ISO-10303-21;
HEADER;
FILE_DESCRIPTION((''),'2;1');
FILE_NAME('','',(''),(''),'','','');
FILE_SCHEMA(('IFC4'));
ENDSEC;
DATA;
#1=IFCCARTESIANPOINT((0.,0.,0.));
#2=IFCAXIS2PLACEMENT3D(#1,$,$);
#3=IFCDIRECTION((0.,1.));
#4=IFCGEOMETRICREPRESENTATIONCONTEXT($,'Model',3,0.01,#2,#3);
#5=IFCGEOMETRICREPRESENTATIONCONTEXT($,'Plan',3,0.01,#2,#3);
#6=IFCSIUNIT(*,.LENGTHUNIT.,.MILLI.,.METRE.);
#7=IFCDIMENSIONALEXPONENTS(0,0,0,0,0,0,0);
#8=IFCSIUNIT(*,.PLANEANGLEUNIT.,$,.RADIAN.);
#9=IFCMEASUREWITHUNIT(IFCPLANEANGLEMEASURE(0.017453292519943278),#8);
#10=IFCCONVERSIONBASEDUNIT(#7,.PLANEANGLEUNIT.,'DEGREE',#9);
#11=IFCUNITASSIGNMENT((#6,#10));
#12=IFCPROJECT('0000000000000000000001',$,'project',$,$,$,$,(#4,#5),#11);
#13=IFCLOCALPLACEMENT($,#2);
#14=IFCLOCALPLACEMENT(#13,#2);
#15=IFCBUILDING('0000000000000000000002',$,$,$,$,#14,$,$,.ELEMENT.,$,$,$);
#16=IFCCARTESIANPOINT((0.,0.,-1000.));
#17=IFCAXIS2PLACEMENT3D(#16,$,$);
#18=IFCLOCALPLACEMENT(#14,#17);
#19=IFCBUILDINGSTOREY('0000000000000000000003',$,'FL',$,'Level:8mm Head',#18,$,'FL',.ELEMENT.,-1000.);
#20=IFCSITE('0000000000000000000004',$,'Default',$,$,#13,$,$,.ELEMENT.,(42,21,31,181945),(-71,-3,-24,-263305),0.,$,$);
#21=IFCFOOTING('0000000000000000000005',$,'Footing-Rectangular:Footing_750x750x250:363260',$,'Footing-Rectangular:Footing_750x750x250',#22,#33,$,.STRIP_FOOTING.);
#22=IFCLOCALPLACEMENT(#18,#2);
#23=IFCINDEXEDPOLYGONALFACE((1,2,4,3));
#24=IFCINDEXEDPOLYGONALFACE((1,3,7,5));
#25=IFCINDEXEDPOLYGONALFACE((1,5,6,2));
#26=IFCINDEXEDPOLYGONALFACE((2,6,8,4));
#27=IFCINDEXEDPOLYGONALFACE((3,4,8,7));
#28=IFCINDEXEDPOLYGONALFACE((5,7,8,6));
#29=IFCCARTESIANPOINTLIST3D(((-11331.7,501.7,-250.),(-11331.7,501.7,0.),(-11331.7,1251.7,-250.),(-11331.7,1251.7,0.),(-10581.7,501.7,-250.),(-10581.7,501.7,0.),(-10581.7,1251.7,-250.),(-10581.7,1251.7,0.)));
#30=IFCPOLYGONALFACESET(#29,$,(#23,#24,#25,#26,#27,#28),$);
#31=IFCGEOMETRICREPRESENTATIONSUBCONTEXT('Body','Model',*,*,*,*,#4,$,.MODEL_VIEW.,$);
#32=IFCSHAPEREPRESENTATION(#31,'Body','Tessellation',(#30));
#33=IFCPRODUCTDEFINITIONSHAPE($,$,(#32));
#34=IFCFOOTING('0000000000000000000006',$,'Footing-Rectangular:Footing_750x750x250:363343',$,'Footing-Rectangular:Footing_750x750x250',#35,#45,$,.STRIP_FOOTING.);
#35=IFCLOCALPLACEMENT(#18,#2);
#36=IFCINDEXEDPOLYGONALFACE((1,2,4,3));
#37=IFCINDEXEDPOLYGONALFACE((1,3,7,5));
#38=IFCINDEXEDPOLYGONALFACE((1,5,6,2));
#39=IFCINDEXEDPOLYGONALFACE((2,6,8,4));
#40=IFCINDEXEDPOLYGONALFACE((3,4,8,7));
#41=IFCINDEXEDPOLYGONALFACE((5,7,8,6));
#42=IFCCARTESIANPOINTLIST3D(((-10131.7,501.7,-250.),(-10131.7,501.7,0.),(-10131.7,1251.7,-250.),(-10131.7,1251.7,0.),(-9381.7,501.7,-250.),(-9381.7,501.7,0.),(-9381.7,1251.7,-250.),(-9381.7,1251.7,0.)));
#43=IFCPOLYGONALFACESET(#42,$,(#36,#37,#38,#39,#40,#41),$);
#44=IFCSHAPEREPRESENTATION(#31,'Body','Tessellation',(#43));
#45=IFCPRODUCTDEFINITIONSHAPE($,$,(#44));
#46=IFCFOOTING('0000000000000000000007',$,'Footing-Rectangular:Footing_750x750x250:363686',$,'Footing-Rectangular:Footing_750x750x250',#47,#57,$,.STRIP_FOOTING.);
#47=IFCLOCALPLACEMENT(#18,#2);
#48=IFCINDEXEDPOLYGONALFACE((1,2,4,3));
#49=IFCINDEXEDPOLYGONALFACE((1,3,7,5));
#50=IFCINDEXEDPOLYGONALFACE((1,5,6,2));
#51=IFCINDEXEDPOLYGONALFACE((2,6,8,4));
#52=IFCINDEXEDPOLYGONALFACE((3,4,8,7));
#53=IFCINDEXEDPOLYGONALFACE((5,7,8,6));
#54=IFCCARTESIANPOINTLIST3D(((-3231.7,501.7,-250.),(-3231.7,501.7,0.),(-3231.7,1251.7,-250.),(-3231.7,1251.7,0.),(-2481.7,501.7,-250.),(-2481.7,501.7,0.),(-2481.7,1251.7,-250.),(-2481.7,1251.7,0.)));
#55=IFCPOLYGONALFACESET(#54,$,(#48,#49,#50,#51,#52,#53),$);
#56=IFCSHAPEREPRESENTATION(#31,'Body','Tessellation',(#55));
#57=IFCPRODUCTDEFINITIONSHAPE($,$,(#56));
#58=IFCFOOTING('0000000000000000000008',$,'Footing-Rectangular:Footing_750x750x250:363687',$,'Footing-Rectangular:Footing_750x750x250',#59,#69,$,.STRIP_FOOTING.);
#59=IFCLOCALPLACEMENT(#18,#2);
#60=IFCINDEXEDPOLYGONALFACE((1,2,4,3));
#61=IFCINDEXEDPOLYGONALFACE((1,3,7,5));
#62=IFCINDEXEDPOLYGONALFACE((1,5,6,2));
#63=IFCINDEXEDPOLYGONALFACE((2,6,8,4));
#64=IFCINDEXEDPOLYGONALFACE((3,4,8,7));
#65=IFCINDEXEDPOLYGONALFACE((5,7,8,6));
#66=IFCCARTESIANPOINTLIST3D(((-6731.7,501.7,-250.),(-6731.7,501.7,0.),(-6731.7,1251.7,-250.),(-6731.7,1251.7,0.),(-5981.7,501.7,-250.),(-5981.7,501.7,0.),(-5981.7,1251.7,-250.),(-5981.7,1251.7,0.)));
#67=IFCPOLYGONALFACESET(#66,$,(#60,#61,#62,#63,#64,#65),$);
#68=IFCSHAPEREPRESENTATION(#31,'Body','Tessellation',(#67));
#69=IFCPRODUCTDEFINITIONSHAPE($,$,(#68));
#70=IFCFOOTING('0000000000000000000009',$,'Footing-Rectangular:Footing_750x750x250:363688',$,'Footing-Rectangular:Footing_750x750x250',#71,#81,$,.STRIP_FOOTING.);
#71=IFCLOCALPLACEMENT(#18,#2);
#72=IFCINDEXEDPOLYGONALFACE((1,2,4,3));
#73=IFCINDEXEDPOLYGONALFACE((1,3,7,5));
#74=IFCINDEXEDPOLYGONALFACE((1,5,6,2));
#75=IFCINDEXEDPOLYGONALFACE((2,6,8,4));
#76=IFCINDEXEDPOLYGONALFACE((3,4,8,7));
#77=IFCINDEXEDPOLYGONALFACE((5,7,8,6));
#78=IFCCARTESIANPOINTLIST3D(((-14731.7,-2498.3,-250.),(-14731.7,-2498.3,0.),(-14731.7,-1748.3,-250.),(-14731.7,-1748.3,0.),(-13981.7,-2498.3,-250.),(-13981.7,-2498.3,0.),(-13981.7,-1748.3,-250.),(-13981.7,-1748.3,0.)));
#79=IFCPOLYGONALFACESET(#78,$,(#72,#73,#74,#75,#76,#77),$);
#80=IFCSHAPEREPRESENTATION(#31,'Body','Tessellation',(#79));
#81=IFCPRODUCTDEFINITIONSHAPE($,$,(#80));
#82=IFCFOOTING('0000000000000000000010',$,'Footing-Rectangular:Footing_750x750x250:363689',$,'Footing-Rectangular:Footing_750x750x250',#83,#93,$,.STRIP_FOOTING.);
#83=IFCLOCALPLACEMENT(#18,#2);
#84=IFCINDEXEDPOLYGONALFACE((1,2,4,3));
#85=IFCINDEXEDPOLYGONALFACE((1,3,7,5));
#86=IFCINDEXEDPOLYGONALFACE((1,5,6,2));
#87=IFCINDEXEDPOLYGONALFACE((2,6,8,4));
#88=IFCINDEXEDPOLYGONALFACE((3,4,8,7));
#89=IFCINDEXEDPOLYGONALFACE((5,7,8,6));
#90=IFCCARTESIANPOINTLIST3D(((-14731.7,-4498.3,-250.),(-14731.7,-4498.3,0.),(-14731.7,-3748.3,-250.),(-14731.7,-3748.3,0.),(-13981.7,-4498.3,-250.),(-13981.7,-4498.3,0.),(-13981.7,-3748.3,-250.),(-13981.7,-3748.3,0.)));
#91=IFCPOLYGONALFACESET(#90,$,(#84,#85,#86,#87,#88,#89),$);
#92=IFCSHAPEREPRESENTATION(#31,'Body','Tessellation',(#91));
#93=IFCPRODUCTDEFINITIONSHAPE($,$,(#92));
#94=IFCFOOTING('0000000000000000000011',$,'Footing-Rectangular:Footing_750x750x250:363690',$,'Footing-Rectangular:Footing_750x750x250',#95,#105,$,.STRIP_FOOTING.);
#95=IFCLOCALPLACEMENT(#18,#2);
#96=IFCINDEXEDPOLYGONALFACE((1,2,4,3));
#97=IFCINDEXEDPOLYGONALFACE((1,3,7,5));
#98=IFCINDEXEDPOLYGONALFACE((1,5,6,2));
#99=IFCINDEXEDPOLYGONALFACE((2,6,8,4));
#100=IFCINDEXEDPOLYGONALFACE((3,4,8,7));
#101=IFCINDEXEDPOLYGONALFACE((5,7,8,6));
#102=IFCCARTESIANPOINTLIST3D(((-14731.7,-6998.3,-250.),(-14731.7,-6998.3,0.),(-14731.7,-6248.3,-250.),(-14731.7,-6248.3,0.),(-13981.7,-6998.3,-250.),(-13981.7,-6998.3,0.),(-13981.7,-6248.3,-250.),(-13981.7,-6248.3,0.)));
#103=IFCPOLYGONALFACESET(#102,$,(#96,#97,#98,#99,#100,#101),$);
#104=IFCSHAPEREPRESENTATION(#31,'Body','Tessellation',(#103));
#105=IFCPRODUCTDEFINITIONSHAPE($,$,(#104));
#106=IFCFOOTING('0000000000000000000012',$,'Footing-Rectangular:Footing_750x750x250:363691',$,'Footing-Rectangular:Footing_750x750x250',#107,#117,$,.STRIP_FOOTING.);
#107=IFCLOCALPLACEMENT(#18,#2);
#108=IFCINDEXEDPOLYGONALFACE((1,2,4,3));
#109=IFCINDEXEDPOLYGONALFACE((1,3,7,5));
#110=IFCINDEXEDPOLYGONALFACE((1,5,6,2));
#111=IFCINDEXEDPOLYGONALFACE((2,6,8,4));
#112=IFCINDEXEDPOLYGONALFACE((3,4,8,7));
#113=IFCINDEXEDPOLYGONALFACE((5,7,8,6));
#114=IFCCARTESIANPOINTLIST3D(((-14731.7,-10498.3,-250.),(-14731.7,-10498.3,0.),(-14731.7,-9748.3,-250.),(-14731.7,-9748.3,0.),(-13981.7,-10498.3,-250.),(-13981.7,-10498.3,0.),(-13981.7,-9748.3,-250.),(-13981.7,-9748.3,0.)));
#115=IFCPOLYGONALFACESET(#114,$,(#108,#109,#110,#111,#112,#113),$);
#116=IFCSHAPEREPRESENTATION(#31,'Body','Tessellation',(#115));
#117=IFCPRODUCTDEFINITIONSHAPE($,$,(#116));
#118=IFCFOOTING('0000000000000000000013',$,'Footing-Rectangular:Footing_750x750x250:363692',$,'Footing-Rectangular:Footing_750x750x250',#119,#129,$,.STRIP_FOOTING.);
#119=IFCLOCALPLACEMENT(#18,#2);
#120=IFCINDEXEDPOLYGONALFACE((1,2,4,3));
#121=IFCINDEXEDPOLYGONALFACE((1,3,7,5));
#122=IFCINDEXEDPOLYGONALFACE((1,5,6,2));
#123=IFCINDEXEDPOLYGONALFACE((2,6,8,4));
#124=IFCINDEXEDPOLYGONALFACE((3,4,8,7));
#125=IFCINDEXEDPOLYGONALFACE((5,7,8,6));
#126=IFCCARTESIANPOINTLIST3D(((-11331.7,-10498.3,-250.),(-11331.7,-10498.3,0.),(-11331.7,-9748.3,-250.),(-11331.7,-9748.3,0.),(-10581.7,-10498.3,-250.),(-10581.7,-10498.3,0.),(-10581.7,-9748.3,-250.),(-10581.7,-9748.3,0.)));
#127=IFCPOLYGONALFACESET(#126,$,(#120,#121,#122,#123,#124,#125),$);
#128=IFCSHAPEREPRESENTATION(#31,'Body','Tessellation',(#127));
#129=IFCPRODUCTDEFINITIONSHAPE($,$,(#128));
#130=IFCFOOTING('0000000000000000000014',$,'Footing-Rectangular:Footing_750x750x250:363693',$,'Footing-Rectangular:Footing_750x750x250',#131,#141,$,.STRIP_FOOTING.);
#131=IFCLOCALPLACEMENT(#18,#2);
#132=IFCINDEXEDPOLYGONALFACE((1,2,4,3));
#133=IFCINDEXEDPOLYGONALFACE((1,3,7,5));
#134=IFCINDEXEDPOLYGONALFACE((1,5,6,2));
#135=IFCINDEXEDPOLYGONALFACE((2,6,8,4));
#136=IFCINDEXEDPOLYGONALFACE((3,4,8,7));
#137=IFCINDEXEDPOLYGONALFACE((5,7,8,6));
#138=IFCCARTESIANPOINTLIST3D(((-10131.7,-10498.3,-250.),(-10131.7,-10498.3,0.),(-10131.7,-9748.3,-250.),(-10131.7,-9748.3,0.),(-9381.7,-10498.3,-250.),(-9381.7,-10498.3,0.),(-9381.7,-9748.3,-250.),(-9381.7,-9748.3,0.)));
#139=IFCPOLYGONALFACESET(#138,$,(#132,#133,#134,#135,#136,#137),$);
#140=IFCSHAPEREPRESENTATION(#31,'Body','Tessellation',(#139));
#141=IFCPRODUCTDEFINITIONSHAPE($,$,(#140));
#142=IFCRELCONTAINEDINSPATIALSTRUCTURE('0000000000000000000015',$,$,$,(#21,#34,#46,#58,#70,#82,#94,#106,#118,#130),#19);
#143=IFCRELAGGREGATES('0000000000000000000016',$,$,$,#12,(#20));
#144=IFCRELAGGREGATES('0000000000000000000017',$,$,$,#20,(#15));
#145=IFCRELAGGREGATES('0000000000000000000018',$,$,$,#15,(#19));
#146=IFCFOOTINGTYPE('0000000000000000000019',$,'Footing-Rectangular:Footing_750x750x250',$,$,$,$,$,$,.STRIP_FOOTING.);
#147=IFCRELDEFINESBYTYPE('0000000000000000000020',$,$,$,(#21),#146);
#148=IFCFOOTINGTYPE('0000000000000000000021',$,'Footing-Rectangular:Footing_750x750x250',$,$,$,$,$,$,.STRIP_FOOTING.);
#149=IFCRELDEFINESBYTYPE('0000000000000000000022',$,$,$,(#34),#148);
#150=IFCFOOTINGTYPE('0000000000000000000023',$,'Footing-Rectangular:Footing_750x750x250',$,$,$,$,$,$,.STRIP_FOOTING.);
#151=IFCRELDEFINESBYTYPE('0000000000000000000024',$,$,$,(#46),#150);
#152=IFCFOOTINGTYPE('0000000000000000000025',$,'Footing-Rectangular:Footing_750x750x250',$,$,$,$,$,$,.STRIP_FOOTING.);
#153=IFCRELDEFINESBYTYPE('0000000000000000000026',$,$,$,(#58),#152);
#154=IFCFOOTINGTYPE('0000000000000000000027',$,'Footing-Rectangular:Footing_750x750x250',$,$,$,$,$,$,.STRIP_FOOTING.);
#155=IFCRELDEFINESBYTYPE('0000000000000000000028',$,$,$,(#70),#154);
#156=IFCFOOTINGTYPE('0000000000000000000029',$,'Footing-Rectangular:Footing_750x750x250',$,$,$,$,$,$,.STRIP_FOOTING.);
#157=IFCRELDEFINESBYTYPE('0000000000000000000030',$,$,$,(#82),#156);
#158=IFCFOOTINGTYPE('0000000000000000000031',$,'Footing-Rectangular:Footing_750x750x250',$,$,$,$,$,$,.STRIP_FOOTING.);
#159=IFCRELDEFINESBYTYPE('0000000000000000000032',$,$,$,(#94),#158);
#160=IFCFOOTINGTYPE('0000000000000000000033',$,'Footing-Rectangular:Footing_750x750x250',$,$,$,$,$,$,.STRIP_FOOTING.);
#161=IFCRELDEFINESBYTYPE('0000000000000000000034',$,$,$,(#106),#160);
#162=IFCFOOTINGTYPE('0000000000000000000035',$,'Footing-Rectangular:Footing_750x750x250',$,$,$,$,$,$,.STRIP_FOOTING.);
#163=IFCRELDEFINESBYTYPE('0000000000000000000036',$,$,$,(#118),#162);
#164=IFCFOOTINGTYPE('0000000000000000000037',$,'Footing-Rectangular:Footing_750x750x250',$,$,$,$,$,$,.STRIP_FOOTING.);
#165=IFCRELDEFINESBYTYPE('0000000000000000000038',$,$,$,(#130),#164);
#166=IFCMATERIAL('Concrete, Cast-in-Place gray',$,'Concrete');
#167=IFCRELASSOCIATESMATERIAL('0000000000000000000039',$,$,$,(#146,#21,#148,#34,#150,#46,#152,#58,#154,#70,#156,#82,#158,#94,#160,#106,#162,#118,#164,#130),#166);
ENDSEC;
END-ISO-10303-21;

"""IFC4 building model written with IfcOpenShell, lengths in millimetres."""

from ifc_helpers import new_model, entity, si_unit, converted_unit, direction, frame, origin, place, context, subcontext, project, spatial, indexed_curve, outline, extrude, source, transform, mapped, material, type_object, type_shapes, element, save


model = new_model("IFC4")

# Units and contexts
model_context = context("Model", 3, precision=0.01, world=origin(), true_north=direction((0.0, 1.0)))
plan_context = context("Plan", 3, precision=0.01, world=origin(), true_north=direction((0.0, 1.0)))
body_context = subcontext(model_context, "Body", "Model", "MODEL_VIEW")
ifc_project = project(units=[si_unit("LENGTHUNIT", "METRE", prefix="MILLI"), converted_unit("PLANEANGLEUNIT", "DEGREE", entity("IfcPlaneAngleMeasure", 0.017453292519943278), si_unit("PLANEANGLEUNIT", "RADIAN"), dimensions=[0, 0, 0, 0, 0, 0, 0])], contexts=[model_context, plan_context])

# Site, building, storey
site_placement = place(None, origin())
site = spatial("IfcSite", under=ifc_project, at=site_placement, Name="Default", CompositionType="ELEMENT", RefLatitude=(42, 21, 31, 181945), RefLongitude=(-71, -3, -24, -263305), RefElevation=0.0)
building_placement = place(site_placement, origin())
building = spatial("IfcBuilding", under=site, at=building_placement, CompositionType="ELEMENT")
storey_placement = place(building_placement, frame((0.0, 0.0, -1000.0)))
storey = spatial("IfcBuildingStorey", under=building, at=storey_placement, Name="FL", ObjectType="Level:8mm Head", LongName="FL", CompositionType="ELEMENT", Elevation=-1000.0)

# Footings
ifc_material = material(Name="Concrete, Cast-in-Place gray", Category="Concrete")
footing_type_1 = type_object("IfcFootingType", Name="Footing-Rectangular:Footing_750x750x250", PredefinedType="STRIP_FOOTING", material=ifc_material)
shared_shape_1 = source(origin(), body_context, "Body", "SweptSolid", [
    extrude(outline(indexed_curve([(-375.0, -375.0), (375.0, -375.0), (375.0, 375.0), (-375.0, 375.0), (-375.0, -375.0)], self_intersect=False)), frame((-10956.7, 876.7, -1250.0), z_axis=(0.0, 0.0, 1.0), x_axis=(-1.0, 0.0, 0.0)), (0.0, 0.0, 1.0), 250.0),
])
type_shapes(footing_type_1, [shared_shape_1])
footing_1_placement = place(storey_placement, frame((0.0, 0.0, 1000.0)))
element("IfcFooting", 1, at=footing_1_placement, inside=storey, type_object=footing_type_1, material=ifc_material, Name="Footing-Rectangular:Footing_750x750x250:363260", ObjectType="Footing-Rectangular:Footing_750x750x250", PredefinedType="STRIP_FOOTING", context=body_context, shape_type="MappedRepresentation", body=[
    mapped(shared_shape_1, transform((0.0, 0.0, 0.0), scale=1.0)),
])
footing_type_2 = type_object("IfcFootingType", Name="Footing-Rectangular:Footing_750x750x250", PredefinedType="STRIP_FOOTING", material=ifc_material)
shared_shape_2 = source(origin(), body_context, "Body", "SweptSolid", [
    extrude(outline(indexed_curve([(-375.0, -375.0), (375.0, -375.0), (375.0, 375.0), (-375.0, 375.0), (-375.0, -375.0)], self_intersect=False)), frame((-9756.7, 876.7, -1250.0), z_axis=(0.0, 0.0, 1.0), x_axis=(-1.0, 0.0, 0.0)), (0.0, 0.0, 1.0), 250.0),
])
type_shapes(footing_type_2, [shared_shape_2])
footing_2_placement = place(storey_placement, frame((0.0, 0.0, 1000.0)))
element("IfcFooting", 2, at=footing_2_placement, inside=storey, type_object=footing_type_2, material=ifc_material, Name="Footing-Rectangular:Footing_750x750x250:363343", ObjectType="Footing-Rectangular:Footing_750x750x250", PredefinedType="STRIP_FOOTING", context=body_context, shape_type="MappedRepresentation", body=[
    mapped(shared_shape_2, transform((0.0, 0.0, 0.0), scale=1.0)),
])
footing_type_3 = type_object("IfcFootingType", Name="Footing-Rectangular:Footing_750x750x250", PredefinedType="STRIP_FOOTING", material=ifc_material)
shared_shape_3 = source(origin(), body_context, "Body", "SweptSolid", [
    extrude(outline(indexed_curve([(-375.0, -375.0), (375.0, -375.0), (375.0, 375.0), (-375.0, 375.0), (-375.0, -375.0)], self_intersect=False)), frame((-2856.7, 876.7, -1250.0), z_axis=(0.0, 0.0, 1.0), x_axis=(0.0, 1.0, 0.0)), (0.0, 0.0, 1.0), 250.0),
])
type_shapes(footing_type_3, [shared_shape_3])
footing_3_placement = place(storey_placement, frame((0.0, 0.0, 1000.0)))
element("IfcFooting", 3, at=footing_3_placement, inside=storey, type_object=footing_type_3, material=ifc_material, Name="Footing-Rectangular:Footing_750x750x250:363686", ObjectType="Footing-Rectangular:Footing_750x750x250", PredefinedType="STRIP_FOOTING", context=body_context, shape_type="MappedRepresentation", body=[
    mapped(shared_shape_3, transform((0.0, 0.0, 0.0), scale=1.0)),
])
footing_type_4 = type_object("IfcFootingType", Name="Footing-Rectangular:Footing_750x750x250", PredefinedType="STRIP_FOOTING", material=ifc_material)
shared_shape_4 = source(origin(), body_context, "Body", "SweptSolid", [
    extrude(outline(indexed_curve([(-375.0, -375.0), (375.0, -375.0), (375.0, 375.0), (-375.0, 375.0), (-375.0, -375.0)], self_intersect=False)), frame((-6356.7, 876.7, -1250.0), z_axis=(0.0, 0.0, 1.0), x_axis=(-1.0, 0.0, 0.0)), (0.0, 0.0, 1.0), 250.0),
])
type_shapes(footing_type_4, [shared_shape_4])
footing_4_placement = place(storey_placement, frame((0.0, 0.0, 1000.0)))
element("IfcFooting", 4, at=footing_4_placement, inside=storey, type_object=footing_type_4, material=ifc_material, Name="Footing-Rectangular:Footing_750x750x250:363687", ObjectType="Footing-Rectangular:Footing_750x750x250", PredefinedType="STRIP_FOOTING", context=body_context, shape_type="MappedRepresentation", body=[
    mapped(shared_shape_4, transform((0.0, 0.0, 0.0), scale=1.0)),
])
footing_type_5 = type_object("IfcFootingType", Name="Footing-Rectangular:Footing_750x750x250", PredefinedType="STRIP_FOOTING", material=ifc_material)
shared_shape_5 = source(origin(), body_context, "Body", "SweptSolid", [
    extrude(outline(indexed_curve([(-375.0, -375.0), (375.0, -375.0), (375.0, 375.0), (-375.0, 375.0), (-375.0, -375.0)], self_intersect=False)), frame((-14356.7, -2123.3, -1250.0), z_axis=(0.0, 0.0, 1.0), x_axis=(-1.0, 0.0, 0.0)), (0.0, 0.0, 1.0), 250.0),
])
type_shapes(footing_type_5, [shared_shape_5])
footing_5_placement = place(storey_placement, frame((0.0, 0.0, 1000.0)))
element("IfcFooting", 5, at=footing_5_placement, inside=storey, type_object=footing_type_5, material=ifc_material, Name="Footing-Rectangular:Footing_750x750x250:363688", ObjectType="Footing-Rectangular:Footing_750x750x250", PredefinedType="STRIP_FOOTING", context=body_context, shape_type="MappedRepresentation", body=[
    mapped(shared_shape_5, transform((0.0, 0.0, 0.0), scale=1.0)),
])
footing_type_6 = type_object("IfcFootingType", Name="Footing-Rectangular:Footing_750x750x250", PredefinedType="STRIP_FOOTING", material=ifc_material)
shared_shape_6 = source(origin(), body_context, "Body", "SweptSolid", [
    extrude(outline(indexed_curve([(-375.0, -375.0), (375.0, -375.0), (375.0, 375.0), (-375.0, 375.0), (-375.0, -375.0)], self_intersect=False)), frame((-14356.7, -4123.3, -1250.0), z_axis=(0.0, 0.0, 1.0), x_axis=(-1.0, 0.0, 0.0)), (0.0, 0.0, 1.0), 250.0),
])
type_shapes(footing_type_6, [shared_shape_6])
footing_6_placement = place(storey_placement, frame((0.0, 0.0, 1000.0)))
element("IfcFooting", 6, at=footing_6_placement, inside=storey, type_object=footing_type_6, material=ifc_material, Name="Footing-Rectangular:Footing_750x750x250:363689", ObjectType="Footing-Rectangular:Footing_750x750x250", PredefinedType="STRIP_FOOTING", context=body_context, shape_type="MappedRepresentation", body=[
    mapped(shared_shape_6, transform((0.0, 0.0, 0.0), scale=1.0)),
])
footing_type_7 = type_object("IfcFootingType", Name="Footing-Rectangular:Footing_750x750x250", PredefinedType="STRIP_FOOTING", material=ifc_material)
shared_shape_7 = source(origin(), body_context, "Body", "SweptSolid", [
    extrude(outline(indexed_curve([(-375.0, -375.0), (375.0, -375.0), (375.0, 375.0), (-375.0, 375.0), (-375.0, -375.0)], self_intersect=False)), frame((-14356.7, -6623.3, -1250.0), z_axis=(0.0, 0.0, 1.0), x_axis=(-1.0, 0.0, 0.0)), (0.0, 0.0, 1.0), 250.0),
])
type_shapes(footing_type_7, [shared_shape_7])
footing_7_placement = place(storey_placement, frame((0.0, 0.0, 1000.0)))
element("IfcFooting", 7, at=footing_7_placement, inside=storey, type_object=footing_type_7, material=ifc_material, Name="Footing-Rectangular:Footing_750x750x250:363690", ObjectType="Footing-Rectangular:Footing_750x750x250", PredefinedType="STRIP_FOOTING", context=body_context, shape_type="MappedRepresentation", body=[
    mapped(shared_shape_7, transform((0.0, 0.0, 0.0), scale=1.0)),
])
footing_type_8 = type_object("IfcFootingType", Name="Footing-Rectangular:Footing_750x750x250", PredefinedType="STRIP_FOOTING", material=ifc_material)
shared_shape_8 = source(origin(), body_context, "Body", "SweptSolid", [
    extrude(outline(indexed_curve([(-375.0, -375.0), (375.0, -375.0), (375.0, 375.0), (-375.0, 375.0), (-375.0, -375.0)], self_intersect=False)), frame((-14356.7, -10123.3, -1250.0), z_axis=(0.0, 0.0, 1.0), x_axis=(0.0, -1.0, 0.0)), (0.0, 0.0, 1.0), 250.0),
])
type_shapes(footing_type_8, [shared_shape_8])
footing_8_placement = place(storey_placement, frame((0.0, 0.0, 1000.0)))
element("IfcFooting", 8, at=footing_8_placement, inside=storey, type_object=footing_type_8, material=ifc_material, Name="Footing-Rectangular:Footing_750x750x250:363691", ObjectType="Footing-Rectangular:Footing_750x750x250", PredefinedType="STRIP_FOOTING", context=body_context, shape_type="MappedRepresentation", body=[
    mapped(shared_shape_8, transform((0.0, 0.0, 0.0), scale=1.0)),
])
footing_type_9 = type_object("IfcFootingType", Name="Footing-Rectangular:Footing_750x750x250", PredefinedType="STRIP_FOOTING", material=ifc_material)
shared_shape_9 = source(origin(), body_context, "Body", "SweptSolid", [
    extrude(outline(indexed_curve([(-375.0, -375.0), (375.0, -375.0), (375.0, 375.0), (-375.0, 375.0), (-375.0, -375.0)], self_intersect=False)), frame((-10956.7, -10123.3, -1250.0)), (0.0, 0.0, 1.0), 250.0),
])
type_shapes(footing_type_9, [shared_shape_9])
footing_9_placement = place(storey_placement, frame((0.0, 0.0, 1000.0)))
element("IfcFooting", 9, at=footing_9_placement, inside=storey, type_object=footing_type_9, material=ifc_material, Name="Footing-Rectangular:Footing_750x750x250:363692", ObjectType="Footing-Rectangular:Footing_750x750x250", PredefinedType="STRIP_FOOTING", context=body_context, shape_type="MappedRepresentation", body=[
    mapped(shared_shape_9, transform((0.0, 0.0, 0.0), scale=1.0)),
])
footing_type_10 = type_object("IfcFootingType", Name="Footing-Rectangular:Footing_750x750x250", PredefinedType="STRIP_FOOTING", material=ifc_material)
shared_shape_10 = source(origin(), body_context, "Body", "SweptSolid", [
    extrude(outline(indexed_curve([(-375.0, -375.0), (375.0, -375.0), (375.0, 375.0), (-375.0, 375.0), (-375.0, -375.0)], self_intersect=False)), frame((-9756.7, -10123.3, -1250.0)), (0.0, 0.0, 1.0), 250.0),
])
type_shapes(footing_type_10, [shared_shape_10])
footing_10_placement = place(storey_placement, frame((0.0, 0.0, 1000.0)))
element("IfcFooting", 10, at=footing_10_placement, inside=storey, type_object=footing_type_10, material=ifc_material, Name="Footing-Rectangular:Footing_750x750x250:363693", ObjectType="Footing-Rectangular:Footing_750x750x250", PredefinedType="STRIP_FOOTING", context=body_context, shape_type="MappedRepresentation", body=[
    mapped(shared_shape_10, transform((0.0, 0.0, 0.0), scale=1.0)),
])

save(model, "model.ifc")
